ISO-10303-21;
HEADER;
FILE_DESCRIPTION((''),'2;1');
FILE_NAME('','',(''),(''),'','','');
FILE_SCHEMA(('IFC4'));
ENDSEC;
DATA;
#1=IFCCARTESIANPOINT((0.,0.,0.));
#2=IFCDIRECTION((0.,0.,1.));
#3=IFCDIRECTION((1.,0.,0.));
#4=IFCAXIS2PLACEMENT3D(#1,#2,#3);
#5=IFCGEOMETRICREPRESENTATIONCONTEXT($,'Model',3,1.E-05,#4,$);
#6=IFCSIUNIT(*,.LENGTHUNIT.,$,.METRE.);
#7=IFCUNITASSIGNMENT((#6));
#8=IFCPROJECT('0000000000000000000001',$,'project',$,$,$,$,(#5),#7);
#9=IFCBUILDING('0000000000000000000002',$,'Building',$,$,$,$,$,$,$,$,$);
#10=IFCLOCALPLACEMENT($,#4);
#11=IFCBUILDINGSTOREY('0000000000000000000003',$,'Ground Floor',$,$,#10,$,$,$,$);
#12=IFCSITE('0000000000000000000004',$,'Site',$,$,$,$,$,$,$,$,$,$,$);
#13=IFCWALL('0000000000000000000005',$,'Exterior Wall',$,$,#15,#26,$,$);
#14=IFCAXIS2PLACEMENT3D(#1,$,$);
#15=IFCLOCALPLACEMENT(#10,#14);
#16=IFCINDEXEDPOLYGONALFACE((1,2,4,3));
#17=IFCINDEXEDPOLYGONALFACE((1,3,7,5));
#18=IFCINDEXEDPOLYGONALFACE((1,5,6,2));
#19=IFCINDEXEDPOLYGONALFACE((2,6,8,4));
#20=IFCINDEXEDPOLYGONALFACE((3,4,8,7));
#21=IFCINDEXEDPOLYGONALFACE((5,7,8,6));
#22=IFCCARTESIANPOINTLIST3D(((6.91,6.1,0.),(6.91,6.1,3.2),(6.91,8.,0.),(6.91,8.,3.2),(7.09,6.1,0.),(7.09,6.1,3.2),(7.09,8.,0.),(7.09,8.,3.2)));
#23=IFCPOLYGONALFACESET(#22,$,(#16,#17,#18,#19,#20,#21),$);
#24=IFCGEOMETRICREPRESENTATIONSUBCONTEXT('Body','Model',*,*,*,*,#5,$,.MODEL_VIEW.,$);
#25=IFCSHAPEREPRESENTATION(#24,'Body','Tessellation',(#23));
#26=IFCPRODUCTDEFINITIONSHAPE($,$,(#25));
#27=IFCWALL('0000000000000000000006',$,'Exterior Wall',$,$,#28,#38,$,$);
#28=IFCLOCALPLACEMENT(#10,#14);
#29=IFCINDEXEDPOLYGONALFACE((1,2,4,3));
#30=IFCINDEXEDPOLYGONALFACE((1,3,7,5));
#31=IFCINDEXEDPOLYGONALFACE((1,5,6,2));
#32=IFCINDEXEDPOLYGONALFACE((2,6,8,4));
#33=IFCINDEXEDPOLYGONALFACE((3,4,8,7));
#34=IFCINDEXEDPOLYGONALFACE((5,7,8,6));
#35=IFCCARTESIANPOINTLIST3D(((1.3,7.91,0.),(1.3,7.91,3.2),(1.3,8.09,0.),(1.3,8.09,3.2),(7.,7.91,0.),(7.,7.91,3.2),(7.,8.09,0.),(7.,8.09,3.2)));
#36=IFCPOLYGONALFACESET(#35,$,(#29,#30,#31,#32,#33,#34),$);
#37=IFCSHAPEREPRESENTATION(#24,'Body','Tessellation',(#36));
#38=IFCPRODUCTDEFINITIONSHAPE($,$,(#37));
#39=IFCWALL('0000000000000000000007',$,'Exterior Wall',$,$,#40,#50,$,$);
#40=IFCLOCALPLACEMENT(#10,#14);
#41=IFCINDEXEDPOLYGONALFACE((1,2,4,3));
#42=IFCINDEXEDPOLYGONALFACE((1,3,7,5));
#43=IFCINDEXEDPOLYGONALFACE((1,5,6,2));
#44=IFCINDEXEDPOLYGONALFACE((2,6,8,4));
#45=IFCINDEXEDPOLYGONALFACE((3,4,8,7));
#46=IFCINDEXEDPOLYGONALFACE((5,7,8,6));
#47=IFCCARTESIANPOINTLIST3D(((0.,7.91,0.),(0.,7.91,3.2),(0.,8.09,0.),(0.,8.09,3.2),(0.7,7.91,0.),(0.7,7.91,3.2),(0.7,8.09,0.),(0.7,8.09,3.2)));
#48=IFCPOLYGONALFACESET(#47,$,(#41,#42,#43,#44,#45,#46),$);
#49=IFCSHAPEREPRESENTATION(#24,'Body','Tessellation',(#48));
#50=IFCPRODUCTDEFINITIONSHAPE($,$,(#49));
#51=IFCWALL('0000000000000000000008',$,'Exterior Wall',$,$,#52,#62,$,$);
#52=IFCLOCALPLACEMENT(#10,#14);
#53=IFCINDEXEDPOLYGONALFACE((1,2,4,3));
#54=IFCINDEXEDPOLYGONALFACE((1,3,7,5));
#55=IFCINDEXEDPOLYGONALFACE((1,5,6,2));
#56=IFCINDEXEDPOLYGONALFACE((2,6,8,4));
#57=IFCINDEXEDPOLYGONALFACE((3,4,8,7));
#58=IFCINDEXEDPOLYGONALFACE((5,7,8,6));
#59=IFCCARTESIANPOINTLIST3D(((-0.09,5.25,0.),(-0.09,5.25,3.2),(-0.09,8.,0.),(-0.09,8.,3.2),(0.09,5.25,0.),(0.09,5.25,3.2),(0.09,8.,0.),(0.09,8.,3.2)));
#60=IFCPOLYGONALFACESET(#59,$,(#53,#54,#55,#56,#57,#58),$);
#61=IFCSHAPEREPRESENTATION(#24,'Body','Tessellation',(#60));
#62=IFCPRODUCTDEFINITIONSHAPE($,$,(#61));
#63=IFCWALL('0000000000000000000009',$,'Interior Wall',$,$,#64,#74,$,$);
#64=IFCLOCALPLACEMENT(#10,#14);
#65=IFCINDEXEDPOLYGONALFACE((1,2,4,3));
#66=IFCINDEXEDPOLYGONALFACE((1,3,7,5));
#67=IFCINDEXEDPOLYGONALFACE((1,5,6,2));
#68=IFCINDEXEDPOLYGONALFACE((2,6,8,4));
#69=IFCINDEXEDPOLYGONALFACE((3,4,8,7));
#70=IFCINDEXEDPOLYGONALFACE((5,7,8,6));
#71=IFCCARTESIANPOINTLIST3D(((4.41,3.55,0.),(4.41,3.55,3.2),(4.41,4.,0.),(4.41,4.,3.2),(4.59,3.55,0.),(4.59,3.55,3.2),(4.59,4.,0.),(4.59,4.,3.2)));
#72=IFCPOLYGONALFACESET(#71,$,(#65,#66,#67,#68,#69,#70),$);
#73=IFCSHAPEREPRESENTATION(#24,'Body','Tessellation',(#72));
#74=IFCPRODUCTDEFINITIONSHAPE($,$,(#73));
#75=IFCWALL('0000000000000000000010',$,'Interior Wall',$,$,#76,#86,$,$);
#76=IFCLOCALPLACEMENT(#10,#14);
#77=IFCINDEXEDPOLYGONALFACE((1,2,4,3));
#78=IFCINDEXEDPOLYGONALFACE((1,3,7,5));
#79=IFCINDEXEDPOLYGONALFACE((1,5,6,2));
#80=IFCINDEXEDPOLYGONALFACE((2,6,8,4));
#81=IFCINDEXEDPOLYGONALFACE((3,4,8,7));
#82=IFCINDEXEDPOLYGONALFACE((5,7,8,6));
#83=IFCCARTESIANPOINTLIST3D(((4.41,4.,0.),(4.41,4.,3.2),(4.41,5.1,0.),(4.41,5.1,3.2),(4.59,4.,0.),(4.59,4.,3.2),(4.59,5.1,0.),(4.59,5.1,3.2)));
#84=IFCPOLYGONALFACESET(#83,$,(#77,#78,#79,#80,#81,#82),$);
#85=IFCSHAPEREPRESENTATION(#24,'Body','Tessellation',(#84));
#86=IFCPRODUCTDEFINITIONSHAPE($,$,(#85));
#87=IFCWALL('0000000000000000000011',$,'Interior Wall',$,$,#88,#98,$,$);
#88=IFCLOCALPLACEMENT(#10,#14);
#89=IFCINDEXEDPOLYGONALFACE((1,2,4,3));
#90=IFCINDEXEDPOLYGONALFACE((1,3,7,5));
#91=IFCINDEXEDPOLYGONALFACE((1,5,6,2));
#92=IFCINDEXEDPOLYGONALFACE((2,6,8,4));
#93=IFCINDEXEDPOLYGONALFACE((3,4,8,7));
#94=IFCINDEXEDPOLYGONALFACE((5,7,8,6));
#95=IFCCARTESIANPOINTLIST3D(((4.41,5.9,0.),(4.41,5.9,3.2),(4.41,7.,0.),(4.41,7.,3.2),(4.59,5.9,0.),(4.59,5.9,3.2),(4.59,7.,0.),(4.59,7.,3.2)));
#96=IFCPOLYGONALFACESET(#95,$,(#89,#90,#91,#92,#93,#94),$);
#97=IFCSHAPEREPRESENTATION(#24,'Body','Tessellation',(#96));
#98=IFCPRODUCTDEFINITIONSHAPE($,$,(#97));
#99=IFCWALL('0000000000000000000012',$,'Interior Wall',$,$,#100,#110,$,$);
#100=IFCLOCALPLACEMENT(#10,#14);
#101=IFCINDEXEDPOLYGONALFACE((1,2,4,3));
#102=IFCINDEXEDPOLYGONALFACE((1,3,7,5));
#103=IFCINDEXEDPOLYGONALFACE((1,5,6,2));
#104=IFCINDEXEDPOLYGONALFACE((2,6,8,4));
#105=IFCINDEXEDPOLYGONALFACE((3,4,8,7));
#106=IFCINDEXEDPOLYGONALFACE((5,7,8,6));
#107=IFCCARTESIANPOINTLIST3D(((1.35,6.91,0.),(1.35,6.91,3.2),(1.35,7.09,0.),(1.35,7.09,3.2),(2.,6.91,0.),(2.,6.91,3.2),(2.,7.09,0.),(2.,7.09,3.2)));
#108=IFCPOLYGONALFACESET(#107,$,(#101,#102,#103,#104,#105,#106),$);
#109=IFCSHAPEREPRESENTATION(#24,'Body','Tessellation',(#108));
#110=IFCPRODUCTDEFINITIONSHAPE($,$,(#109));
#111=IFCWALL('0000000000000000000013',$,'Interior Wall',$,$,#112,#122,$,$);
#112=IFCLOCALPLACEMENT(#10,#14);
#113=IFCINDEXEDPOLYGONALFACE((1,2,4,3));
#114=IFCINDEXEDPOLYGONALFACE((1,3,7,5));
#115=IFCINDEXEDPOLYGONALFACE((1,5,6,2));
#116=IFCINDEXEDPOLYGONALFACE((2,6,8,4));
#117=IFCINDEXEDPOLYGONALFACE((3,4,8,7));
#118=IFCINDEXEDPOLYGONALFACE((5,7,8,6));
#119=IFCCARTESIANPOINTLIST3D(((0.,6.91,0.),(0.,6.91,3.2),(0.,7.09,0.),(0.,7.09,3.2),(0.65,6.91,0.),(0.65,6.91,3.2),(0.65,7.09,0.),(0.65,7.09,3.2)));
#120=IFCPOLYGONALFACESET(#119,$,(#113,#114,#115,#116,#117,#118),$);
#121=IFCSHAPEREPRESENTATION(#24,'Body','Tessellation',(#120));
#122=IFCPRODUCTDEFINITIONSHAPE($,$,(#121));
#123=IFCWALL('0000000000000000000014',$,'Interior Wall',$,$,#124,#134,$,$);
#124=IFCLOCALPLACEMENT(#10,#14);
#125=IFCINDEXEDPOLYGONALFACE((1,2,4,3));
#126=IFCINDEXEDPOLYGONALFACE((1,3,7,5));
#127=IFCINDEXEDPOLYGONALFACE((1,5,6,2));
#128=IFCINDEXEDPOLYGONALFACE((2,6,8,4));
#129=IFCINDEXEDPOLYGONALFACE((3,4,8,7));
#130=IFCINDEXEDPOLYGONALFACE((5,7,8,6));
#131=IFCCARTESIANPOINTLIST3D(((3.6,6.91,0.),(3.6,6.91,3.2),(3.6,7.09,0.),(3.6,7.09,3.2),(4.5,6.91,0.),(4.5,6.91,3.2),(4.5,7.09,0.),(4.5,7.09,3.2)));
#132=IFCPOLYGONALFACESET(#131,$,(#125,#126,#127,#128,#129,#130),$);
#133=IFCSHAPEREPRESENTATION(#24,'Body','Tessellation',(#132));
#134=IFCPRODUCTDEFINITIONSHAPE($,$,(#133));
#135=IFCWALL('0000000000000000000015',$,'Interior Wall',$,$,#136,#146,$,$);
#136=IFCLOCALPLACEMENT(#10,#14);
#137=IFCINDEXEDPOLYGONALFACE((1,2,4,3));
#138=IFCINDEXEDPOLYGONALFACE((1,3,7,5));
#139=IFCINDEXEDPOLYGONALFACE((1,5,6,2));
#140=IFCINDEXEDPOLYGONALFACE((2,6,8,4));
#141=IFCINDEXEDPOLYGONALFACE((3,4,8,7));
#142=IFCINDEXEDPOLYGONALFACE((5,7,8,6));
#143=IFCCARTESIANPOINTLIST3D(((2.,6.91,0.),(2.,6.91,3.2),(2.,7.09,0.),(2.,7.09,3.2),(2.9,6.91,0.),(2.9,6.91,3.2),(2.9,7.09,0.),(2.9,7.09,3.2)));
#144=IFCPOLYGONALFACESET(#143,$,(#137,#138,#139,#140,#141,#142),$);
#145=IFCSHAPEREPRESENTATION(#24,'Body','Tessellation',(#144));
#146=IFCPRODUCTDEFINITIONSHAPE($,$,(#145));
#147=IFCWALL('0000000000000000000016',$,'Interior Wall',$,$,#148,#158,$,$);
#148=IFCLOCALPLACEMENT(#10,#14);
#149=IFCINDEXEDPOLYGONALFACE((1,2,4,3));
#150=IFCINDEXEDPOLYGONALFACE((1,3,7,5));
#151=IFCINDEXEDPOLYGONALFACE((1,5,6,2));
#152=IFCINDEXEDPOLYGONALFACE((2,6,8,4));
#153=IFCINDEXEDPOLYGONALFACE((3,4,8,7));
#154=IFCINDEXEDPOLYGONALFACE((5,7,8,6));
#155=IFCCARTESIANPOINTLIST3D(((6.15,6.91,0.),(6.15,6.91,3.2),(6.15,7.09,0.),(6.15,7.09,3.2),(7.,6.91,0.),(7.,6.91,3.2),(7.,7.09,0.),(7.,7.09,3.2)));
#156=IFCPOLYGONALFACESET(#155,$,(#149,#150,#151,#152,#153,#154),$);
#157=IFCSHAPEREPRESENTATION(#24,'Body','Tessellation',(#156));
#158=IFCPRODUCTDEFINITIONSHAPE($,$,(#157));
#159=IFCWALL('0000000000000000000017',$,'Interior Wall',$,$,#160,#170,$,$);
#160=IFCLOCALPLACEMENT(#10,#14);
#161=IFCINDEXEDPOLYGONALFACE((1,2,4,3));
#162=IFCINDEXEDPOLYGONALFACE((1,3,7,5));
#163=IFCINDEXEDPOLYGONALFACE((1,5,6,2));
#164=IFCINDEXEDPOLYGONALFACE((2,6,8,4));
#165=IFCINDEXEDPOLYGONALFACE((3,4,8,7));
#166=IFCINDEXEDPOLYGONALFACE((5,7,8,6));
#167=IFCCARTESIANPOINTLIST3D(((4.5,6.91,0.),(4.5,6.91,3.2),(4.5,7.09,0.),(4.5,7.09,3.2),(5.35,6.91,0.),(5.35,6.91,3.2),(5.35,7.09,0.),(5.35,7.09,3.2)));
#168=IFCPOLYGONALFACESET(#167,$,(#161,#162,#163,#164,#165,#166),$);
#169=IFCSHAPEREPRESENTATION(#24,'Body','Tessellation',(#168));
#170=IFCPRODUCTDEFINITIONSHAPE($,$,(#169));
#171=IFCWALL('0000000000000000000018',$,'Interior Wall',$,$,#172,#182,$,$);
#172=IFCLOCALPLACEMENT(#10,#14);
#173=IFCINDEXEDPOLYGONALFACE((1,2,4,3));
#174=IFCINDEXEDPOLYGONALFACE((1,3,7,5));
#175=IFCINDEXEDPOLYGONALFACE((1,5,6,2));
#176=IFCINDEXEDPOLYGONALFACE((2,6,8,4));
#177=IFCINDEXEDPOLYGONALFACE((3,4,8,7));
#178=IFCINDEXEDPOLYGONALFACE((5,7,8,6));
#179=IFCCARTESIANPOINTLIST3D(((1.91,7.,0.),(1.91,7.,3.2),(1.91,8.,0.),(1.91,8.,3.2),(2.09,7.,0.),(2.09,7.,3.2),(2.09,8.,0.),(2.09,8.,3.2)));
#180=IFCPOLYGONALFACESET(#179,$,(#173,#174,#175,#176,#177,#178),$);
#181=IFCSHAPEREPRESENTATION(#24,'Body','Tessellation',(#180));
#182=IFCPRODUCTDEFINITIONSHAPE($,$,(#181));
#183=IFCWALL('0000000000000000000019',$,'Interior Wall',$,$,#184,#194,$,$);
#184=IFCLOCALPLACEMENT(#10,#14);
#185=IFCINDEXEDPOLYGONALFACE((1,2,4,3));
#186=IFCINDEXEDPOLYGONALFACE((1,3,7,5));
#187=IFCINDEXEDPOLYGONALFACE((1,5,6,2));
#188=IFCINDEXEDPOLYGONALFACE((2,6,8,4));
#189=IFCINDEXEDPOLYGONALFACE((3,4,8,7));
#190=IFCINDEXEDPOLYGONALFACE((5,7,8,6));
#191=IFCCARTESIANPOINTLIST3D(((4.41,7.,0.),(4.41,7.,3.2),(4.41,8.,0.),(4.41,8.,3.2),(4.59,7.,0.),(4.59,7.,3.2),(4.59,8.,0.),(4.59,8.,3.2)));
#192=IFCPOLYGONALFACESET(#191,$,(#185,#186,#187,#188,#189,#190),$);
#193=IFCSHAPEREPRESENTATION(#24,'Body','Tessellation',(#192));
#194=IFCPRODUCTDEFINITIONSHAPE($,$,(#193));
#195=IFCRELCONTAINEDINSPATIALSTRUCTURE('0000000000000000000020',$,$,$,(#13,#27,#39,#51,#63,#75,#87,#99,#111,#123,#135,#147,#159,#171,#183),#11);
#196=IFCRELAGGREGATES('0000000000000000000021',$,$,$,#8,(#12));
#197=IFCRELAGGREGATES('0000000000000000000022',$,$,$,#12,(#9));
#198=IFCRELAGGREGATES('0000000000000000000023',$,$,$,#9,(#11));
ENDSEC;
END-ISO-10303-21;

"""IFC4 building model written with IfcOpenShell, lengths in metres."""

from ifc_helpers import new_model, si_unit, frame, origin_with_axes, place, context, subcontext, project, spatial, indexed_curve, outline, extrude, element, save


model = new_model("IFC4")

# Units and contexts
model_context = context("Model", 3, precision=1e-05, world=origin_with_axes())
body_context = subcontext(model_context, "Body", "Model", "MODEL_VIEW")
ifc_project = project(units=[si_unit("LENGTHUNIT", "METRE")], contexts=[model_context])

# Site, building, storey
site = spatial("IfcSite", under=ifc_project, Name="Site")
building = spatial("IfcBuilding", under=site, Name="Building")
storey_placement = place(None, origin_with_axes())
storey = spatial("IfcBuildingStorey", under=building, at=storey_placement, Name="Ground Floor")

# Walls
wall_1_placement = place(storey_placement, frame((7.0, 6.1, 0.0), z_axis=(0.0, 0.0, 1.0), x_axis=(0.0, 1.0, 0.0)))
element("IfcWall", 1, at=wall_1_placement, inside=storey, Name="Exterior Wall", context=body_context, shape_type="SweptSolid", body=[
    extrude(outline(indexed_curve([(0.0, 0.0), (0.0, 0.18), (1.9, 0.18), (1.9, 0.0), (0.0, 0.0)], self_intersect=False)), frame((0.0, -0.09, 0.0), z_axis=(0.0, 0.0, 1.0), x_axis=(1.0, 0.0, 0.0)), (0.0, 0.0, 1.0), 3.2),
])
wall_2_placement = place(storey_placement, frame((7.0, 8.0, 0.0), z_axis=(0.0, 0.0, 1.0), x_axis=(-1.0, 0.0, 0.0)))
element("IfcWall", 2, at=wall_2_placement, inside=storey, Name="Exterior Wall", context=body_context, shape_type="SweptSolid", body=[
    extrude(outline(indexed_curve([(0.0, 0.0), (0.0, 0.18), (5.7, 0.18), (5.7, 0.0), (0.0, 0.0)], self_intersect=False)), frame((0.0, -0.09, 0.0), z_axis=(0.0, 0.0, 1.0), x_axis=(1.0, 0.0, 0.0)), (0.0, 0.0, 1.0), 3.2),
])
wall_3_placement = place(storey_placement, frame((0.7, 8.0, 0.0), z_axis=(0.0, 0.0, 1.0), x_axis=(-1.0, 0.0, 0.0)))
element("IfcWall", 3, at=wall_3_placement, inside=storey, Name="Exterior Wall", context=body_context, shape_type="SweptSolid", body=[
    extrude(outline(indexed_curve([(0.0, 0.0), (0.0, 0.18), (0.7, 0.18), (0.7, 0.0), (0.0, 0.0)], self_intersect=False)), frame((0.0, -0.09, 0.0), z_axis=(0.0, 0.0, 1.0), x_axis=(1.0, 0.0, 0.0)), (0.0, 0.0, 1.0), 3.2),
])
wall_4_placement = place(storey_placement, frame((0.0, 8.0, 0.0), z_axis=(0.0, 0.0, 1.0), x_axis=(0.0, -1.0, 0.0)))
element("IfcWall", 4, at=wall_4_placement, inside=storey, Name="Exterior Wall", context=body_context, shape_type="SweptSolid", body=[
    extrude(outline(indexed_curve([(0.0, 0.0), (0.0, 0.18), (2.75, 0.18), (2.75, 0.0), (0.0, 0.0)], self_intersect=False)), frame((0.0, -0.09, 0.0), z_axis=(0.0, 0.0, 1.0), x_axis=(1.0, 0.0, 0.0)), (0.0, 0.0, 1.0), 3.2),
])
wall_5_placement = place(storey_placement, frame((4.5, 4.0, 0.0), z_axis=(0.0, 0.0, 1.0), x_axis=(0.0, -1.0, 0.0)))
element("IfcWall", 5, at=wall_5_placement, inside=storey, Name="Interior Wall", context=body_context, shape_type="SweptSolid", body=[
    extrude(outline(indexed_curve([(0.0, 0.0), (0.0, 0.18), (0.45, 0.18), (0.45, 0.0), (0.0, 0.0)], self_intersect=False)), frame((0.0, -0.09, 0.0), z_axis=(0.0, 0.0, 1.0), x_axis=(1.0, 0.0, 0.0)), (0.0, 0.0, 1.0), 3.2),
])
for number, where, z_axis, x_axis, name in (
    (6, (4.5, 4.0, 0.0), (0.0, 0.0, 1.0), (0.0, 1.0, 0.0), "Interior Wall"),
    (7, (4.5, 5.9, 0.0), (0.0, 0.0, 1.0), (0.0, 1.0, 0.0), "Interior Wall"),
):
    element("IfcWall", number, at=place(storey_placement, frame(where, z_axis=z_axis, x_axis=x_axis)), inside=storey, Name=name, context=body_context, shape_type="SweptSolid", body=[
        extrude(outline(indexed_curve([(0.0, 0.0), (0.0, 0.18), (1.1, 0.18), (1.1, 0.0), (0.0, 0.0)], self_intersect=False)), frame((0.0, -0.09, 0.0), z_axis=(0.0, 0.0, 1.0), x_axis=(1.0, 0.0, 0.0)), (0.0, 0.0, 1.0), 3.2),
    ])
for number, where, z_axis, x_axis, name in (
    (8, (2.0, 7.0, 0.0), (0.0, 0.0, 1.0), (-1.0, 0.0, 0.0), "Interior Wall"),
    (9, (0.65, 7.0, 0.0), (0.0, 0.0, 1.0), (-1.0, 0.0, 0.0), "Interior Wall"),
):
    element("IfcWall", number, at=place(storey_placement, frame(where, z_axis=z_axis, x_axis=x_axis)), inside=storey, Name=name, context=body_context, shape_type="SweptSolid", body=[
        extrude(outline(indexed_curve([(0.0, 0.0), (0.0, 0.18), (0.65, 0.18), (0.65, 0.0), (0.0, 0.0)], self_intersect=False)), frame((0.0, -0.09, 0.0), z_axis=(0.0, 0.0, 1.0), x_axis=(1.0, 0.0, 0.0)), (0.0, 0.0, 1.0), 3.2),
    ])
for number, where, z_axis, x_axis, name in (
    (10, (4.5, 7.0, 0.0), (0.0, 0.0, 1.0), (-1.0, 0.0, 0.0), "Interior Wall"),
    (11, (2.9, 7.0, 0.0), (0.0, 0.0, 1.0), (-1.0, 0.0, 0.0), "Interior Wall"),
):
    element("IfcWall", number, at=place(storey_placement, frame(where, z_axis=z_axis, x_axis=x_axis)), inside=storey, Name=name, context=body_context, shape_type="SweptSolid", body=[
        extrude(outline(indexed_curve([(0.0, 0.0), (0.0, 0.18), (0.9, 0.18), (0.9, 0.0), (0.0, 0.0)], self_intersect=False)), frame((0.0, -0.09, 0.0), z_axis=(0.0, 0.0, 1.0), x_axis=(1.0, 0.0, 0.0)), (0.0, 0.0, 1.0), 3.2),
    ])
for number, where, z_axis, x_axis, name in (
    (12, (7.0, 7.0, 0.0), (0.0, 0.0, 1.0), (-1.0, 0.0, 0.0), "Interior Wall"),
    (13, (5.35, 7.0, 0.0), (0.0, 0.0, 1.0), (-1.0, 0.0, 0.0), "Interior Wall"),
):
    element("IfcWall", number, at=place(storey_placement, frame(where, z_axis=z_axis, x_axis=x_axis)), inside=storey, Name=name, context=body_context, shape_type="SweptSolid", body=[
        extrude(outline(indexed_curve([(0.0, 0.0), (0.0, 0.18), (0.85, 0.18), (0.85, 0.0), (0.0, 0.0)], self_intersect=False)), frame((0.0, -0.09, 0.0), z_axis=(0.0, 0.0, 1.0), x_axis=(1.0, 0.0, 0.0)), (0.0, 0.0, 1.0), 3.2),
    ])
for number, where, z_axis, x_axis, name in (
    (14, (2.0, 7.0, 0.0), (0.0, 0.0, 1.0), (0.0, 1.0, 0.0), "Interior Wall"),
    (15, (4.5, 7.0, 0.0), (0.0, 0.0, 1.0), (0.0, 1.0, 0.0), "Interior Wall"),
):
    element("IfcWall", number, at=place(storey_placement, frame(where, z_axis=z_axis, x_axis=x_axis)), inside=storey, Name=name, context=body_context, shape_type="SweptSolid", body=[
        extrude(outline(indexed_curve([(0.0, 0.0), (0.0, 0.18), (1.0, 0.18), (1.0, 0.0), (0.0, 0.0)], self_intersect=False)), frame((0.0, -0.09, 0.0), z_axis=(0.0, 0.0, 1.0), x_axis=(1.0, 0.0, 0.0)), (0.0, 0.0, 1.0), 3.2),
    ])

save(model, "model.ifc")
